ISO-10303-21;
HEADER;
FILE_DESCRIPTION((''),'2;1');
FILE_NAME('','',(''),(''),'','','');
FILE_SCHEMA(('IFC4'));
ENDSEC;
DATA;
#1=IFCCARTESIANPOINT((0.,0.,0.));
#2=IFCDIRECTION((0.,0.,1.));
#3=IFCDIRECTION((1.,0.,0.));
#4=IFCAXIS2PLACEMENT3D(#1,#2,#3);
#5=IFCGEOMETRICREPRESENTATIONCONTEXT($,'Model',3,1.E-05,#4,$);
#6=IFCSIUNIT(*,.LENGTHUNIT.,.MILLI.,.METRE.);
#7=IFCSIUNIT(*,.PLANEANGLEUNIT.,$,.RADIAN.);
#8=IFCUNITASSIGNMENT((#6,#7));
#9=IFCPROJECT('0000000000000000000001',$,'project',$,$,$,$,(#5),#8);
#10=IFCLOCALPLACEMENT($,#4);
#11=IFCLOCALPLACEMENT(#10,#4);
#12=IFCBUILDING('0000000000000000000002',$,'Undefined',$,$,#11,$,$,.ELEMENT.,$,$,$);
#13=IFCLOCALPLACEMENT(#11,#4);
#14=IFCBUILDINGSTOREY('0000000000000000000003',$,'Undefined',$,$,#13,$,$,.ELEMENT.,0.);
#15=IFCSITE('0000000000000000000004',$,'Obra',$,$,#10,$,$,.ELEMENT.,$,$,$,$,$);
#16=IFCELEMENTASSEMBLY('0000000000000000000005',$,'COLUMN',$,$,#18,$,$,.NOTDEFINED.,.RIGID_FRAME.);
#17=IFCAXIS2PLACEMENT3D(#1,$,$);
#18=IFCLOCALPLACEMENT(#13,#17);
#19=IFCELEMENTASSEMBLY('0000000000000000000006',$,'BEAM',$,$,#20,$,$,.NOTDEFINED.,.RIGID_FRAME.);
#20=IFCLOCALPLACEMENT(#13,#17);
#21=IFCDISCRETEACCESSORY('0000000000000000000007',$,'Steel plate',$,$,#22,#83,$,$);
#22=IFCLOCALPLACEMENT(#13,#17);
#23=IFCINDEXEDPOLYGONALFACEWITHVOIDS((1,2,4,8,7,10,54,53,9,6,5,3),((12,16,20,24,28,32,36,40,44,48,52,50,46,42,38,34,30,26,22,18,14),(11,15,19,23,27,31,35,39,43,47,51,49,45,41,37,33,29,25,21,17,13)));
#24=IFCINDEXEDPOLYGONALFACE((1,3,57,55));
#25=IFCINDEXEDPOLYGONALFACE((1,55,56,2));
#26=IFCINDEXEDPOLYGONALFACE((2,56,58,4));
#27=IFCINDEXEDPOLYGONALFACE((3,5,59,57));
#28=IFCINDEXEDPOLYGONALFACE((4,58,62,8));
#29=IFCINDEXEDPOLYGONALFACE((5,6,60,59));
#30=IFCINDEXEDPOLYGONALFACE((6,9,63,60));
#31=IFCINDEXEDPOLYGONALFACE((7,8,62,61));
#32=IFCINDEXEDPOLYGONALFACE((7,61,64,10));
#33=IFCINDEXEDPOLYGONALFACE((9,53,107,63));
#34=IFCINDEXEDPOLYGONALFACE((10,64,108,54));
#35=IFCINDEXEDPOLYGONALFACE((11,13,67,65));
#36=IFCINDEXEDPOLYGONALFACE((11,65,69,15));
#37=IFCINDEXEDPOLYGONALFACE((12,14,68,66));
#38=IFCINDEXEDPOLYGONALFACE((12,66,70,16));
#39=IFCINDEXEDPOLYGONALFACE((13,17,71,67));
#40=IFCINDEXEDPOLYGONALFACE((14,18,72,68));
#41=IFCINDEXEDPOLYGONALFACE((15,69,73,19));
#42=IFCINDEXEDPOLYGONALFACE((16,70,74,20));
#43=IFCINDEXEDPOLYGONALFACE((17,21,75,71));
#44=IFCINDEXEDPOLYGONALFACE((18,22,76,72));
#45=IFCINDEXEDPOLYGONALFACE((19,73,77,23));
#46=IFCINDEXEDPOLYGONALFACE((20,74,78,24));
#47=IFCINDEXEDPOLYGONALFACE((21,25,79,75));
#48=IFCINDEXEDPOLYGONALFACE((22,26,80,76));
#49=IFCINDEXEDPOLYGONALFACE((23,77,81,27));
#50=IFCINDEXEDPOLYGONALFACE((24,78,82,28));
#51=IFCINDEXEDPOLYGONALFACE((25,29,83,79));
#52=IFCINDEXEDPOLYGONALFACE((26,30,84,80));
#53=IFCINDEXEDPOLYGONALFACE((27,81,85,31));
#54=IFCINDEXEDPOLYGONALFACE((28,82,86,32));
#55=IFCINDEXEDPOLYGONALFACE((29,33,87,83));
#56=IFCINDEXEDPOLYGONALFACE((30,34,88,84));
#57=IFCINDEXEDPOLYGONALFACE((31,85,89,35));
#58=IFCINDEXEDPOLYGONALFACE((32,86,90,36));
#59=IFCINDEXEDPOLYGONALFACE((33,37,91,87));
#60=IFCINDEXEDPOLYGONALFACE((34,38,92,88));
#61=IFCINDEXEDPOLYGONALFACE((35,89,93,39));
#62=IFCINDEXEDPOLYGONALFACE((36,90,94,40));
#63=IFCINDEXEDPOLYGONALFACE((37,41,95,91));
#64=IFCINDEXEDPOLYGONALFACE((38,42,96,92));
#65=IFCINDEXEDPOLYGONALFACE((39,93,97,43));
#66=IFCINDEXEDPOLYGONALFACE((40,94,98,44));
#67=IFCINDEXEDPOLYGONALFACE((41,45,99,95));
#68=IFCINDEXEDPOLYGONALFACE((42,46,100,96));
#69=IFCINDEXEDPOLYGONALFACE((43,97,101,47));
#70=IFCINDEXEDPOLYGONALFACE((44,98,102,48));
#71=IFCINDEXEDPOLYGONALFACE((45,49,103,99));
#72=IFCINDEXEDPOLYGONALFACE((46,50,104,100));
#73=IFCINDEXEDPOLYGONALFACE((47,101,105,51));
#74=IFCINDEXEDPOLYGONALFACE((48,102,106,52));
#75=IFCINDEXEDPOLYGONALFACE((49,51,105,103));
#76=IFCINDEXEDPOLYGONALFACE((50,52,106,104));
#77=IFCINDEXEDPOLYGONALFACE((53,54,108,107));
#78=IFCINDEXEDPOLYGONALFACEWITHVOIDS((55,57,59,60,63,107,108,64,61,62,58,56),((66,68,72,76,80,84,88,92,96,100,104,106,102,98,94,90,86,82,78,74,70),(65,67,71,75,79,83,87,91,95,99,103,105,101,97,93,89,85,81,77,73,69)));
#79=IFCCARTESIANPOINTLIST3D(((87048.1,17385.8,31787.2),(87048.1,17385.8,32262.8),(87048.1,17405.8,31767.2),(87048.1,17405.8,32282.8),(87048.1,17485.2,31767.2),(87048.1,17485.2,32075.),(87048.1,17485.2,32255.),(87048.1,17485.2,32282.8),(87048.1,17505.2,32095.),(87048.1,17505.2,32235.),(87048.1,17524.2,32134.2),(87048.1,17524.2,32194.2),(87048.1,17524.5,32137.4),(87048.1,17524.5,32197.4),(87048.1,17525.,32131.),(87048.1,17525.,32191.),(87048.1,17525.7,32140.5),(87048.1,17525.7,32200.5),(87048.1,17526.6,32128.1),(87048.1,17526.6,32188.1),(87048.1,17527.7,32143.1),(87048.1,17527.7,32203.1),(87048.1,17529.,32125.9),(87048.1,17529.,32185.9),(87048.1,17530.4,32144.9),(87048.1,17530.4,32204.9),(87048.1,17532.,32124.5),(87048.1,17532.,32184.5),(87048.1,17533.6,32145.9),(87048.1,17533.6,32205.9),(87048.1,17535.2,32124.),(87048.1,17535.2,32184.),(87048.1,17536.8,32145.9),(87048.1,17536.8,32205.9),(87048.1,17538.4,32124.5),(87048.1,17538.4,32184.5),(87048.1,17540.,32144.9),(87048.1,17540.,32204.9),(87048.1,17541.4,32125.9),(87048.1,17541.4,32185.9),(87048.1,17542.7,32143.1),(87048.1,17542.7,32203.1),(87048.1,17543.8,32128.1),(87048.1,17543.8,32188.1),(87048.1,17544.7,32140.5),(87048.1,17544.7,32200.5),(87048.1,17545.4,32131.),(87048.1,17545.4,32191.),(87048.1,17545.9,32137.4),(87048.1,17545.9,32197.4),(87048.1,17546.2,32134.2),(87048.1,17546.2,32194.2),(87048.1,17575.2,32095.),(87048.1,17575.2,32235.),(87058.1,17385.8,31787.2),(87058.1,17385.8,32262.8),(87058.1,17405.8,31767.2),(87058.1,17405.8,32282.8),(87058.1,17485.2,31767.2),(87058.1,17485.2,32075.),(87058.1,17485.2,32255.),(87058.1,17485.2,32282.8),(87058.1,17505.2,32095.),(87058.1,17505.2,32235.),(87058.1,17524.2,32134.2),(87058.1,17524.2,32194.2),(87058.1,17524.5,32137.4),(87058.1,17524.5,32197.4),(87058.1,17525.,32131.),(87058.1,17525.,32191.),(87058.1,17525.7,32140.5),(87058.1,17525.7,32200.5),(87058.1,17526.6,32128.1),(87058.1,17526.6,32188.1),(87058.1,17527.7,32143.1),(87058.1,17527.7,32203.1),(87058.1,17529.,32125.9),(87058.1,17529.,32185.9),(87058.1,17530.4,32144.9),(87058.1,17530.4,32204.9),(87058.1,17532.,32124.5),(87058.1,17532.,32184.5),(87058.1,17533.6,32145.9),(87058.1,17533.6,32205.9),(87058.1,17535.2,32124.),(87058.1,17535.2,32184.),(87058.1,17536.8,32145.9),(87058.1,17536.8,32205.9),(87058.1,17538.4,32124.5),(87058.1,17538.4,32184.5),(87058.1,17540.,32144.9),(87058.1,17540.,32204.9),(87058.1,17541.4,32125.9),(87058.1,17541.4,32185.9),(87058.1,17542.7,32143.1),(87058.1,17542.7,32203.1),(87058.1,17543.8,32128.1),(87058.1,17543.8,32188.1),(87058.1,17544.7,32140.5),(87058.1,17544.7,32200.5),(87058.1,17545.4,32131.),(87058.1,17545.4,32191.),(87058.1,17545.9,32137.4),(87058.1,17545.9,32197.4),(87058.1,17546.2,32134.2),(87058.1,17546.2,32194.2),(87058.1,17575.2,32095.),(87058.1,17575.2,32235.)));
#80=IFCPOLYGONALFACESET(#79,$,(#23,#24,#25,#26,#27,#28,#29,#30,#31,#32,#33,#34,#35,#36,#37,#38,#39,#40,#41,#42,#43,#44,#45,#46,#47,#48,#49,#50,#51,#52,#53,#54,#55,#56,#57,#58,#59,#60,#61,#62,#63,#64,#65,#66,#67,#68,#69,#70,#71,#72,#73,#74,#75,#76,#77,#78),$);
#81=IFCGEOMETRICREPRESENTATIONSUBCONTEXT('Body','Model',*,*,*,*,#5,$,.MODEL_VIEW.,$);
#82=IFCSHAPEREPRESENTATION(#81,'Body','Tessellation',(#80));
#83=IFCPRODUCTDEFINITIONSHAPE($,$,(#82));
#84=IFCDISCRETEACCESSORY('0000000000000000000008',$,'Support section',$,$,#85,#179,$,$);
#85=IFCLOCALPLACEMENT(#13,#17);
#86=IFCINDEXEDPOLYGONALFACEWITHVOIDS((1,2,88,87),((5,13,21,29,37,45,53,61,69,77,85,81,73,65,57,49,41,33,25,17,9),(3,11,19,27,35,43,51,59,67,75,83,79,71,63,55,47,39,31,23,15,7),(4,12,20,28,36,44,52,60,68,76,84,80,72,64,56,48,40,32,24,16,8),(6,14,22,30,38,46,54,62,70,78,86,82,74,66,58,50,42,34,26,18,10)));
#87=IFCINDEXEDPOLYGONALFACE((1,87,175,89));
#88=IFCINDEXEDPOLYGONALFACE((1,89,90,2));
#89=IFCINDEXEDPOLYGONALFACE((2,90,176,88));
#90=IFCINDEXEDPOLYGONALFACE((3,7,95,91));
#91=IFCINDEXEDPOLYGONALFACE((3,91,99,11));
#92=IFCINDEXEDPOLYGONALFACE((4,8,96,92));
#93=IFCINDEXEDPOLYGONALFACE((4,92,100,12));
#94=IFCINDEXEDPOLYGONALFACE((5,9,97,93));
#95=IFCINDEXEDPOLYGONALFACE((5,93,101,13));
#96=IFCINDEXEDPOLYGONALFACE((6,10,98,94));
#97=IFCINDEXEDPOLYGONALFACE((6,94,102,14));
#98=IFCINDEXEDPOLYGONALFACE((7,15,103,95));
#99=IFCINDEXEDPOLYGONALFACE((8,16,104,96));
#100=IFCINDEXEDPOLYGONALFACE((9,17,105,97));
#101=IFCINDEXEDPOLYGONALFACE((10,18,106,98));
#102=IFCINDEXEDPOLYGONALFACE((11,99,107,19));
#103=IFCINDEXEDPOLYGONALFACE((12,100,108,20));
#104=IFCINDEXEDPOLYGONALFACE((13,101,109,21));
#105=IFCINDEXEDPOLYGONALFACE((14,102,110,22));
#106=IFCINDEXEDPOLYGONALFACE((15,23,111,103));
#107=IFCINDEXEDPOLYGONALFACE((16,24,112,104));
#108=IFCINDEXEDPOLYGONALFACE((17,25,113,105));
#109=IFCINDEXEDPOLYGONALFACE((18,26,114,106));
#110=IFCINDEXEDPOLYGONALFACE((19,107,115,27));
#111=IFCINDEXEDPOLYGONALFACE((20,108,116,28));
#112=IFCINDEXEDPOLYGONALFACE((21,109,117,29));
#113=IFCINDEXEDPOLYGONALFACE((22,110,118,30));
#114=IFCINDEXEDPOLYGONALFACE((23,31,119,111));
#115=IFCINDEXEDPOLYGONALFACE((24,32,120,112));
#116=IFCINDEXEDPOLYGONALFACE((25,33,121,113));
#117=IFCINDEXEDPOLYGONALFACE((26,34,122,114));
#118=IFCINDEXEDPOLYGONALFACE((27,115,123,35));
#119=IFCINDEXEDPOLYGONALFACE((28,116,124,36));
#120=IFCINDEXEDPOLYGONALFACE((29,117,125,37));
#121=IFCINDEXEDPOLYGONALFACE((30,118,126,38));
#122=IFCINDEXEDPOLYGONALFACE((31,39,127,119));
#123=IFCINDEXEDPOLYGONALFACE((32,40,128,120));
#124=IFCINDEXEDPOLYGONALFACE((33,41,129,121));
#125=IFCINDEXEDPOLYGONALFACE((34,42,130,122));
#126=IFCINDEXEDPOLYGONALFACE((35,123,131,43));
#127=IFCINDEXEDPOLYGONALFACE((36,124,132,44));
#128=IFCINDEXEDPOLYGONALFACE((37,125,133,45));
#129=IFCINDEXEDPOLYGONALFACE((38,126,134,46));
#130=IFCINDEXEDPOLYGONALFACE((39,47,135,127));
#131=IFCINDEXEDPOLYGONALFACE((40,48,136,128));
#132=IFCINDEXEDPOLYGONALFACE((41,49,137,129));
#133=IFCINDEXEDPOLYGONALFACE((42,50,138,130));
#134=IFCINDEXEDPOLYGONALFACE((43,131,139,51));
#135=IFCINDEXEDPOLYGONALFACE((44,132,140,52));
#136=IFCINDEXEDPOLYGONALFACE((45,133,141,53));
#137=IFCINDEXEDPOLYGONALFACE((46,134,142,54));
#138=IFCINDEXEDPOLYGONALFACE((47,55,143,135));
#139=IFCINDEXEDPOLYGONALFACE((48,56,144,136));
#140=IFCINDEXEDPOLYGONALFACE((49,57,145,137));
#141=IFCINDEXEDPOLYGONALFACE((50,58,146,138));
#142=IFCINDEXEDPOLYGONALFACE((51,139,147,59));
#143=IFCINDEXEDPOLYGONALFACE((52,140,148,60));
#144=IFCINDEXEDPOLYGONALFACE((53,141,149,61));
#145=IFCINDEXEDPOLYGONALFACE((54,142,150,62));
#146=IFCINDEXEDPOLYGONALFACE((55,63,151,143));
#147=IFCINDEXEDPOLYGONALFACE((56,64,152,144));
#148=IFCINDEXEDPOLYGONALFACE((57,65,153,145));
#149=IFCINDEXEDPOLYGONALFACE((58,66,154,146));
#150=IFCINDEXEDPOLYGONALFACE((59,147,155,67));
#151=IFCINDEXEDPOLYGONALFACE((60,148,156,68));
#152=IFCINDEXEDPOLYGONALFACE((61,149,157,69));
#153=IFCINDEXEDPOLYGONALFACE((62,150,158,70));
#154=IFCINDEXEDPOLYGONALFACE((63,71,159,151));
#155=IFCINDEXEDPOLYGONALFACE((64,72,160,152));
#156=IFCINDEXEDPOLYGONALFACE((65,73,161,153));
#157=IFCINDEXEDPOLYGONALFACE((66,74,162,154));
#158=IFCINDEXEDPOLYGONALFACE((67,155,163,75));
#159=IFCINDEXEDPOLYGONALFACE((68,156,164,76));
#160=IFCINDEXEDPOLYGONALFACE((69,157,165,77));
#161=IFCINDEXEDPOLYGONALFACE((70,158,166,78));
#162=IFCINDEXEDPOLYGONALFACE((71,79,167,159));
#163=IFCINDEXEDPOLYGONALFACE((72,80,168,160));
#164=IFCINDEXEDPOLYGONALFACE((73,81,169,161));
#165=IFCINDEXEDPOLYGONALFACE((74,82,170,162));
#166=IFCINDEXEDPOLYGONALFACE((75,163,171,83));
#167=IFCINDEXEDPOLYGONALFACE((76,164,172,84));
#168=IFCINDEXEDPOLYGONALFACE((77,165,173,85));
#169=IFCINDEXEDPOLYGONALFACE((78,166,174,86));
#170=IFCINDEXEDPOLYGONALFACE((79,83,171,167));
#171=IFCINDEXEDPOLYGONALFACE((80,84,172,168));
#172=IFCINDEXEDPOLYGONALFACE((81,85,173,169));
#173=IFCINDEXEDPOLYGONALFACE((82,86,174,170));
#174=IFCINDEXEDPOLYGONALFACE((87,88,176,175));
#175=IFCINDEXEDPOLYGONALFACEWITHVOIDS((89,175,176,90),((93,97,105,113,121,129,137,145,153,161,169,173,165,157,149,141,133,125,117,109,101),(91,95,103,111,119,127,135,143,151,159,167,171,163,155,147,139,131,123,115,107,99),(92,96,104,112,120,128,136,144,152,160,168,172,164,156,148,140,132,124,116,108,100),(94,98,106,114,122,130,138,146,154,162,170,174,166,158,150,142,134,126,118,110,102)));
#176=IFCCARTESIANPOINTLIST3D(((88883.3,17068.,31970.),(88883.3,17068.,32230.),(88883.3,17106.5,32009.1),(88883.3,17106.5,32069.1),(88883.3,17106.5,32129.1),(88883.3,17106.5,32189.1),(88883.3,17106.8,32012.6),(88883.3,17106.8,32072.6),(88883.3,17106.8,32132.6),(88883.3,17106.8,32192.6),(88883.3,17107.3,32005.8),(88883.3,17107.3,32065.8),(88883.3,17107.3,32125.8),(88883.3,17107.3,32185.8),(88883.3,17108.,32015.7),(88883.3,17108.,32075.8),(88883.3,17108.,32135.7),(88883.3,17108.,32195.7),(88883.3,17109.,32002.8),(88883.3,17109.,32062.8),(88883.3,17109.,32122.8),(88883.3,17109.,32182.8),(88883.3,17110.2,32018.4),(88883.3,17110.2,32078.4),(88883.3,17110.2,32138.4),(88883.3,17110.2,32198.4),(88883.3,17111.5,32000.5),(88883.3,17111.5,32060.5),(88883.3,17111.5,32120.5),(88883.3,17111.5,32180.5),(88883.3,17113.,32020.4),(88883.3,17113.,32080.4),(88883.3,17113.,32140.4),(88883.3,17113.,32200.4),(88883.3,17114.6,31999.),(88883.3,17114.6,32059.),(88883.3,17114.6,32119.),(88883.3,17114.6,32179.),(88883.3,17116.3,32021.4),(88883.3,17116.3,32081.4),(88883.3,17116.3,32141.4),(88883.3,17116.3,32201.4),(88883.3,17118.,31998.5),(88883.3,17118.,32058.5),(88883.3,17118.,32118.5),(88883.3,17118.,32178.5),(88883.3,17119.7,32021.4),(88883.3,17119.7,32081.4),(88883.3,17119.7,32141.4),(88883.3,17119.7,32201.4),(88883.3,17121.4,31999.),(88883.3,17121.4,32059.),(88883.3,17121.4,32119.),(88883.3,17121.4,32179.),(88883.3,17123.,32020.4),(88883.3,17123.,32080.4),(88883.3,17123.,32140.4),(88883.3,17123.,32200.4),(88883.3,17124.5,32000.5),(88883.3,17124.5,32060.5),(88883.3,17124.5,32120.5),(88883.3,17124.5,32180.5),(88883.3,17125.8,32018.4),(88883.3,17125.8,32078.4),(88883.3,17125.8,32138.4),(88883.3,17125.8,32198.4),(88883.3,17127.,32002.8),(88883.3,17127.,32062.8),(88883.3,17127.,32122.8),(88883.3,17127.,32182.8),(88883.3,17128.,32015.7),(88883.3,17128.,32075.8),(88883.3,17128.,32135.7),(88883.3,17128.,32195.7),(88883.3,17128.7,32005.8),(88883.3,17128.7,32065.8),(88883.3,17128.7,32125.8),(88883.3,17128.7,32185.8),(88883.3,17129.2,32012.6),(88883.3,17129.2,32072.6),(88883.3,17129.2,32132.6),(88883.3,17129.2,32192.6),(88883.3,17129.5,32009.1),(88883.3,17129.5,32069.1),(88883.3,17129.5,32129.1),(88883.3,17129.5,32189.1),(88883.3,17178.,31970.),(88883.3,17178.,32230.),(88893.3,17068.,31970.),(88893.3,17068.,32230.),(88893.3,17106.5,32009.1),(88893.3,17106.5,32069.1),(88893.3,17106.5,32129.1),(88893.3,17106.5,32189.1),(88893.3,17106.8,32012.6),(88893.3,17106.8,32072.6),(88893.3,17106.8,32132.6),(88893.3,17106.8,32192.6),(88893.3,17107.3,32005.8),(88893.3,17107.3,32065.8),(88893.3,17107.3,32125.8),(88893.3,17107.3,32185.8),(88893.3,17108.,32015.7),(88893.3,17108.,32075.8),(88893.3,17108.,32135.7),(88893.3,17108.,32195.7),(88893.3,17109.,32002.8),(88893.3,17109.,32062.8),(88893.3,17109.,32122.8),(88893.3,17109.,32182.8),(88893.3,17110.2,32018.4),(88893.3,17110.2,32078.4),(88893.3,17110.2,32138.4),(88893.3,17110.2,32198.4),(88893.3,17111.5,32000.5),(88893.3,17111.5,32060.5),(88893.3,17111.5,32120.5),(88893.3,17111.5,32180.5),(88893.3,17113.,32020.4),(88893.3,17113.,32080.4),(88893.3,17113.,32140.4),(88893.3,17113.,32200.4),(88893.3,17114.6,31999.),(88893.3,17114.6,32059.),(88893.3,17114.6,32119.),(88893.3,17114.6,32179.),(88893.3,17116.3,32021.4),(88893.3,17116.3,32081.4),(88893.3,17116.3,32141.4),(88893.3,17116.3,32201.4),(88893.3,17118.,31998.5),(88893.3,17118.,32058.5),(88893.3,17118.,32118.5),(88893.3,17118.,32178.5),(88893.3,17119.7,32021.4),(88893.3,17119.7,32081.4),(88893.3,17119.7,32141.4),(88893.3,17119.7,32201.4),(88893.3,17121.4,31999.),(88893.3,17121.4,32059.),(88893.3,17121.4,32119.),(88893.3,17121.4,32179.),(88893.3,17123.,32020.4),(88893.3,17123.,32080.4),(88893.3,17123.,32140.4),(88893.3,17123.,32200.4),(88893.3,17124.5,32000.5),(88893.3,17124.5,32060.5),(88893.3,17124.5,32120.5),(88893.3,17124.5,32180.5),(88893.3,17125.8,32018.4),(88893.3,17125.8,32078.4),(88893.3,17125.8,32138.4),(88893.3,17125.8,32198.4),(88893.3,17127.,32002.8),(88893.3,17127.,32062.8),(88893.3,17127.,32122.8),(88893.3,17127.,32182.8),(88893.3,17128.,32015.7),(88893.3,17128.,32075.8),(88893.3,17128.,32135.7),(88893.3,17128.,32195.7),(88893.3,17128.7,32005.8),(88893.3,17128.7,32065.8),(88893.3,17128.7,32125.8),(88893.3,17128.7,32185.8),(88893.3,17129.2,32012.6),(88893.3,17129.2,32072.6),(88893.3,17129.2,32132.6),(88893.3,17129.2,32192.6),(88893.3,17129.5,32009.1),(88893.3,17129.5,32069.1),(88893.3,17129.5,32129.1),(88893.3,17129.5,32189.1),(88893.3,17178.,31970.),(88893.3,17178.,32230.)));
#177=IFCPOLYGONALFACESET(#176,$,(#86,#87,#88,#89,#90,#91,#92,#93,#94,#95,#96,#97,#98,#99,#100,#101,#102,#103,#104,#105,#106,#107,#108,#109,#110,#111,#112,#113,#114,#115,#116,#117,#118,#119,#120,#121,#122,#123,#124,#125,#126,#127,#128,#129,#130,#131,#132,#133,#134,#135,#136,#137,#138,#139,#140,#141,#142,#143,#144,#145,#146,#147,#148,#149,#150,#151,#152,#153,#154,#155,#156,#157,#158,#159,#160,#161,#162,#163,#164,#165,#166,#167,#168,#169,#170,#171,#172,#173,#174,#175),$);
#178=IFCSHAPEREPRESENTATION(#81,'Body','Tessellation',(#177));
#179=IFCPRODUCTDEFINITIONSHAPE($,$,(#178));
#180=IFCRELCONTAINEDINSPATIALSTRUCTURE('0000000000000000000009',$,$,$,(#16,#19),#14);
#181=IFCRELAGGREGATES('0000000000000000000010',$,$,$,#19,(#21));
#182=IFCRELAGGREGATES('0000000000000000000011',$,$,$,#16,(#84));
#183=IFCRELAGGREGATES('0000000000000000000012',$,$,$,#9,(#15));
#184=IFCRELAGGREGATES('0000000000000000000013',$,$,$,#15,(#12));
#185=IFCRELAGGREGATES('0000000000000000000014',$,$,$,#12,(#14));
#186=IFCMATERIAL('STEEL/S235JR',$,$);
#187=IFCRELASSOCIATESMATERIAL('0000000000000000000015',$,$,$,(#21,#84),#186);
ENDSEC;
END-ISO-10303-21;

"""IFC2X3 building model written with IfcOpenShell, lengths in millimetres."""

from ifc_helpers import new_model, si_unit, frame, origin_with_axes, origin_2d_with_axis, place, context, subcontext, project, spatial, polyline, rectangle, circle, outline, extrude, source, transform, mapped, material, element, aggregate, save


model = new_model("IFC2X3")

# Units and contexts
model_context = context("Model", 3, precision=1e-05, world=origin_with_axes())
body_context = subcontext(model_context, "Body", "Model", "MODEL_VIEW")
ifc_project = project(units=[si_unit("LENGTHUNIT", "METRE", prefix="MILLI"), si_unit("PLANEANGLEUNIT", "RADIAN")], contexts=[model_context])

# Site, building, storey
site_placement = place(None, origin_with_axes())
site = spatial("IfcSite", under=ifc_project, at=site_placement, Name="Obra", CompositionType="ELEMENT")
building_placement = place(site_placement, origin_with_axes())
building = spatial("IfcBuilding", under=site, at=building_placement, Name="Undefined", CompositionType="ELEMENT")
storey_placement = place(building_placement, origin_with_axes())
storey = spatial("IfcBuildingStorey", under=building, at=storey_placement, Name="Undefined", CompositionType="ELEMENT", Elevation=0.0)

# Element assembly
ifc_material_1 = material(Name="STEEL/S235JR")
assembly_1_placement = place(storey_placement, origin_with_axes())
assembly_1 = element("IfcElementAssembly", 1, at=assembly_1_placement, inside=storey, Name="COLUMN", AssemblyPlace="NOTDEFINED", PredefinedType="RIGID_FRAME")

# Element assembly
assembly_2_placement = place(storey_placement, origin_with_axes())
assembly_2 = element("IfcElementAssembly", 2, at=assembly_2_placement, inside=storey, Name="BEAM", AssemblyPlace="NOTDEFINED", PredefinedType="RIGID_FRAME")

# Discrete accessories, openings
discrete_accessory_1_placement = place(assembly_2_placement, frame((87053.1, 17385.8, 31787.2), z_axis=(1.0, 0.0, 0.0), x_axis=(0.0, 0.707107, -0.707107)))
discrete_accessory_1 = element("IfcDiscreteAccessory", 3, at=discrete_accessory_1_placement, material=ifc_material_1, Name="Steel plate", context=body_context, shape_type="SweptSolid", body=[
    extrude(outline(polyline([(0.0, 0.0), (28.3, 0.0), (84.5, 56.2), (-133.2, 273.8), (-133.2, 302.1), (-83.7, 351.6), (-182.7, 450.6), (-232.2, 401.1), (-260.5, 401.1), (-280.1, 420.8), (-336.3, 364.6), (-336.3, 336.3), (0.0, 0.0)])), frame((0.0, 0.0, -5.0), z_axis=(0.0, 0.0, 1.0), x_axis=(1.0, 0.0, 0.0)), (0.0, 0.0, 1.0), 10.0),
])
shared_shape_1 = source(origin_with_axes(), body_context, "Body", "SweptSolid", [
    extrude(circle(Radius=11.0, at=origin_2d_with_axis()), frame((0.0, -13.4, 0.0), z_axis=(0.0, 1.0, 0.0), x_axis=(1.0, 0.0, 0.0)), (0.0, 0.0, 1.0), 10.2),
])
opening_1_placement = place(assembly_2_placement, frame((87044.8, 17495.2, 32235.0), z_axis=(0.0, 1.0, 0.0), x_axis=(0.0, 0.0, -1.0)))
element("IfcOpeningElement", 4, at=opening_1_placement, cuts=discrete_accessory_1, ObjectType="Opening", context=body_context, shape_type="MappedRepresentation", body=[
    mapped(shared_shape_1, transform((40.0, 0.0, 40.0))),
    mapped(shared_shape_1, transform((100.0, 0.0, 40.0))),
])
aggregate(assembly_2, [discrete_accessory_1])
discrete_accessory_2_placement = place(assembly_1_placement, frame((88888.3, 17123.0, 31970.0), z_axis=(0.0, 0.0, 1.0), x_axis=(0.0, 1.0, 0.0)))
discrete_accessory_2 = element("IfcDiscreteAccessory", 5, at=discrete_accessory_2_placement, material=ifc_material_1, Name="Support section", context=body_context, shape_type="SweptSolid", body=[
    extrude(rectangle(XDim=10.0, YDim=110.0, at=origin_2d_with_axis()), frame((0.0, 0.0, 260.0), z_axis=(0.0, 0.0, -1.0), x_axis=(0.0, 1.0, 0.0)), (0.0, 0.0, 1.0), 260.0),
])
shared_shape_2 = source(origin_with_axes(), body_context, "Body", "SweptSolid", [
    extrude(circle(Radius=11.5, at=origin_2d_with_axis()), frame((0.0, -14.4, 0.0), z_axis=(0.0, 1.0, 0.0), x_axis=(1.0, 0.0, 0.0)), (0.0, 0.0, 1.0), 10.2),
])
opening_2_placement = place(assembly_1_placement, frame((88897.6, 17168.0, 32300.0), z_axis=(0.0, -1.0, 0.0), x_axis=(0.0, 0.0, -1.0)))
element("IfcOpeningElement", 6, at=opening_2_placement, cuts=discrete_accessory_2, ObjectType="Opening", context=body_context, shape_type="MappedRepresentation", body=[
    mapped(shared_shape_2, transform((110.0, 0.0, 50.0))),
    mapped(shared_shape_2, transform((170.0, 0.0, 50.0))),
    mapped(shared_shape_2, transform((230.0, 0.0, 50.0))),
    mapped(shared_shape_2, transform((290.0, 0.0, 50.0))),
])
aggregate(assembly_1, [discrete_accessory_2])

save(model, "model.ifc")
